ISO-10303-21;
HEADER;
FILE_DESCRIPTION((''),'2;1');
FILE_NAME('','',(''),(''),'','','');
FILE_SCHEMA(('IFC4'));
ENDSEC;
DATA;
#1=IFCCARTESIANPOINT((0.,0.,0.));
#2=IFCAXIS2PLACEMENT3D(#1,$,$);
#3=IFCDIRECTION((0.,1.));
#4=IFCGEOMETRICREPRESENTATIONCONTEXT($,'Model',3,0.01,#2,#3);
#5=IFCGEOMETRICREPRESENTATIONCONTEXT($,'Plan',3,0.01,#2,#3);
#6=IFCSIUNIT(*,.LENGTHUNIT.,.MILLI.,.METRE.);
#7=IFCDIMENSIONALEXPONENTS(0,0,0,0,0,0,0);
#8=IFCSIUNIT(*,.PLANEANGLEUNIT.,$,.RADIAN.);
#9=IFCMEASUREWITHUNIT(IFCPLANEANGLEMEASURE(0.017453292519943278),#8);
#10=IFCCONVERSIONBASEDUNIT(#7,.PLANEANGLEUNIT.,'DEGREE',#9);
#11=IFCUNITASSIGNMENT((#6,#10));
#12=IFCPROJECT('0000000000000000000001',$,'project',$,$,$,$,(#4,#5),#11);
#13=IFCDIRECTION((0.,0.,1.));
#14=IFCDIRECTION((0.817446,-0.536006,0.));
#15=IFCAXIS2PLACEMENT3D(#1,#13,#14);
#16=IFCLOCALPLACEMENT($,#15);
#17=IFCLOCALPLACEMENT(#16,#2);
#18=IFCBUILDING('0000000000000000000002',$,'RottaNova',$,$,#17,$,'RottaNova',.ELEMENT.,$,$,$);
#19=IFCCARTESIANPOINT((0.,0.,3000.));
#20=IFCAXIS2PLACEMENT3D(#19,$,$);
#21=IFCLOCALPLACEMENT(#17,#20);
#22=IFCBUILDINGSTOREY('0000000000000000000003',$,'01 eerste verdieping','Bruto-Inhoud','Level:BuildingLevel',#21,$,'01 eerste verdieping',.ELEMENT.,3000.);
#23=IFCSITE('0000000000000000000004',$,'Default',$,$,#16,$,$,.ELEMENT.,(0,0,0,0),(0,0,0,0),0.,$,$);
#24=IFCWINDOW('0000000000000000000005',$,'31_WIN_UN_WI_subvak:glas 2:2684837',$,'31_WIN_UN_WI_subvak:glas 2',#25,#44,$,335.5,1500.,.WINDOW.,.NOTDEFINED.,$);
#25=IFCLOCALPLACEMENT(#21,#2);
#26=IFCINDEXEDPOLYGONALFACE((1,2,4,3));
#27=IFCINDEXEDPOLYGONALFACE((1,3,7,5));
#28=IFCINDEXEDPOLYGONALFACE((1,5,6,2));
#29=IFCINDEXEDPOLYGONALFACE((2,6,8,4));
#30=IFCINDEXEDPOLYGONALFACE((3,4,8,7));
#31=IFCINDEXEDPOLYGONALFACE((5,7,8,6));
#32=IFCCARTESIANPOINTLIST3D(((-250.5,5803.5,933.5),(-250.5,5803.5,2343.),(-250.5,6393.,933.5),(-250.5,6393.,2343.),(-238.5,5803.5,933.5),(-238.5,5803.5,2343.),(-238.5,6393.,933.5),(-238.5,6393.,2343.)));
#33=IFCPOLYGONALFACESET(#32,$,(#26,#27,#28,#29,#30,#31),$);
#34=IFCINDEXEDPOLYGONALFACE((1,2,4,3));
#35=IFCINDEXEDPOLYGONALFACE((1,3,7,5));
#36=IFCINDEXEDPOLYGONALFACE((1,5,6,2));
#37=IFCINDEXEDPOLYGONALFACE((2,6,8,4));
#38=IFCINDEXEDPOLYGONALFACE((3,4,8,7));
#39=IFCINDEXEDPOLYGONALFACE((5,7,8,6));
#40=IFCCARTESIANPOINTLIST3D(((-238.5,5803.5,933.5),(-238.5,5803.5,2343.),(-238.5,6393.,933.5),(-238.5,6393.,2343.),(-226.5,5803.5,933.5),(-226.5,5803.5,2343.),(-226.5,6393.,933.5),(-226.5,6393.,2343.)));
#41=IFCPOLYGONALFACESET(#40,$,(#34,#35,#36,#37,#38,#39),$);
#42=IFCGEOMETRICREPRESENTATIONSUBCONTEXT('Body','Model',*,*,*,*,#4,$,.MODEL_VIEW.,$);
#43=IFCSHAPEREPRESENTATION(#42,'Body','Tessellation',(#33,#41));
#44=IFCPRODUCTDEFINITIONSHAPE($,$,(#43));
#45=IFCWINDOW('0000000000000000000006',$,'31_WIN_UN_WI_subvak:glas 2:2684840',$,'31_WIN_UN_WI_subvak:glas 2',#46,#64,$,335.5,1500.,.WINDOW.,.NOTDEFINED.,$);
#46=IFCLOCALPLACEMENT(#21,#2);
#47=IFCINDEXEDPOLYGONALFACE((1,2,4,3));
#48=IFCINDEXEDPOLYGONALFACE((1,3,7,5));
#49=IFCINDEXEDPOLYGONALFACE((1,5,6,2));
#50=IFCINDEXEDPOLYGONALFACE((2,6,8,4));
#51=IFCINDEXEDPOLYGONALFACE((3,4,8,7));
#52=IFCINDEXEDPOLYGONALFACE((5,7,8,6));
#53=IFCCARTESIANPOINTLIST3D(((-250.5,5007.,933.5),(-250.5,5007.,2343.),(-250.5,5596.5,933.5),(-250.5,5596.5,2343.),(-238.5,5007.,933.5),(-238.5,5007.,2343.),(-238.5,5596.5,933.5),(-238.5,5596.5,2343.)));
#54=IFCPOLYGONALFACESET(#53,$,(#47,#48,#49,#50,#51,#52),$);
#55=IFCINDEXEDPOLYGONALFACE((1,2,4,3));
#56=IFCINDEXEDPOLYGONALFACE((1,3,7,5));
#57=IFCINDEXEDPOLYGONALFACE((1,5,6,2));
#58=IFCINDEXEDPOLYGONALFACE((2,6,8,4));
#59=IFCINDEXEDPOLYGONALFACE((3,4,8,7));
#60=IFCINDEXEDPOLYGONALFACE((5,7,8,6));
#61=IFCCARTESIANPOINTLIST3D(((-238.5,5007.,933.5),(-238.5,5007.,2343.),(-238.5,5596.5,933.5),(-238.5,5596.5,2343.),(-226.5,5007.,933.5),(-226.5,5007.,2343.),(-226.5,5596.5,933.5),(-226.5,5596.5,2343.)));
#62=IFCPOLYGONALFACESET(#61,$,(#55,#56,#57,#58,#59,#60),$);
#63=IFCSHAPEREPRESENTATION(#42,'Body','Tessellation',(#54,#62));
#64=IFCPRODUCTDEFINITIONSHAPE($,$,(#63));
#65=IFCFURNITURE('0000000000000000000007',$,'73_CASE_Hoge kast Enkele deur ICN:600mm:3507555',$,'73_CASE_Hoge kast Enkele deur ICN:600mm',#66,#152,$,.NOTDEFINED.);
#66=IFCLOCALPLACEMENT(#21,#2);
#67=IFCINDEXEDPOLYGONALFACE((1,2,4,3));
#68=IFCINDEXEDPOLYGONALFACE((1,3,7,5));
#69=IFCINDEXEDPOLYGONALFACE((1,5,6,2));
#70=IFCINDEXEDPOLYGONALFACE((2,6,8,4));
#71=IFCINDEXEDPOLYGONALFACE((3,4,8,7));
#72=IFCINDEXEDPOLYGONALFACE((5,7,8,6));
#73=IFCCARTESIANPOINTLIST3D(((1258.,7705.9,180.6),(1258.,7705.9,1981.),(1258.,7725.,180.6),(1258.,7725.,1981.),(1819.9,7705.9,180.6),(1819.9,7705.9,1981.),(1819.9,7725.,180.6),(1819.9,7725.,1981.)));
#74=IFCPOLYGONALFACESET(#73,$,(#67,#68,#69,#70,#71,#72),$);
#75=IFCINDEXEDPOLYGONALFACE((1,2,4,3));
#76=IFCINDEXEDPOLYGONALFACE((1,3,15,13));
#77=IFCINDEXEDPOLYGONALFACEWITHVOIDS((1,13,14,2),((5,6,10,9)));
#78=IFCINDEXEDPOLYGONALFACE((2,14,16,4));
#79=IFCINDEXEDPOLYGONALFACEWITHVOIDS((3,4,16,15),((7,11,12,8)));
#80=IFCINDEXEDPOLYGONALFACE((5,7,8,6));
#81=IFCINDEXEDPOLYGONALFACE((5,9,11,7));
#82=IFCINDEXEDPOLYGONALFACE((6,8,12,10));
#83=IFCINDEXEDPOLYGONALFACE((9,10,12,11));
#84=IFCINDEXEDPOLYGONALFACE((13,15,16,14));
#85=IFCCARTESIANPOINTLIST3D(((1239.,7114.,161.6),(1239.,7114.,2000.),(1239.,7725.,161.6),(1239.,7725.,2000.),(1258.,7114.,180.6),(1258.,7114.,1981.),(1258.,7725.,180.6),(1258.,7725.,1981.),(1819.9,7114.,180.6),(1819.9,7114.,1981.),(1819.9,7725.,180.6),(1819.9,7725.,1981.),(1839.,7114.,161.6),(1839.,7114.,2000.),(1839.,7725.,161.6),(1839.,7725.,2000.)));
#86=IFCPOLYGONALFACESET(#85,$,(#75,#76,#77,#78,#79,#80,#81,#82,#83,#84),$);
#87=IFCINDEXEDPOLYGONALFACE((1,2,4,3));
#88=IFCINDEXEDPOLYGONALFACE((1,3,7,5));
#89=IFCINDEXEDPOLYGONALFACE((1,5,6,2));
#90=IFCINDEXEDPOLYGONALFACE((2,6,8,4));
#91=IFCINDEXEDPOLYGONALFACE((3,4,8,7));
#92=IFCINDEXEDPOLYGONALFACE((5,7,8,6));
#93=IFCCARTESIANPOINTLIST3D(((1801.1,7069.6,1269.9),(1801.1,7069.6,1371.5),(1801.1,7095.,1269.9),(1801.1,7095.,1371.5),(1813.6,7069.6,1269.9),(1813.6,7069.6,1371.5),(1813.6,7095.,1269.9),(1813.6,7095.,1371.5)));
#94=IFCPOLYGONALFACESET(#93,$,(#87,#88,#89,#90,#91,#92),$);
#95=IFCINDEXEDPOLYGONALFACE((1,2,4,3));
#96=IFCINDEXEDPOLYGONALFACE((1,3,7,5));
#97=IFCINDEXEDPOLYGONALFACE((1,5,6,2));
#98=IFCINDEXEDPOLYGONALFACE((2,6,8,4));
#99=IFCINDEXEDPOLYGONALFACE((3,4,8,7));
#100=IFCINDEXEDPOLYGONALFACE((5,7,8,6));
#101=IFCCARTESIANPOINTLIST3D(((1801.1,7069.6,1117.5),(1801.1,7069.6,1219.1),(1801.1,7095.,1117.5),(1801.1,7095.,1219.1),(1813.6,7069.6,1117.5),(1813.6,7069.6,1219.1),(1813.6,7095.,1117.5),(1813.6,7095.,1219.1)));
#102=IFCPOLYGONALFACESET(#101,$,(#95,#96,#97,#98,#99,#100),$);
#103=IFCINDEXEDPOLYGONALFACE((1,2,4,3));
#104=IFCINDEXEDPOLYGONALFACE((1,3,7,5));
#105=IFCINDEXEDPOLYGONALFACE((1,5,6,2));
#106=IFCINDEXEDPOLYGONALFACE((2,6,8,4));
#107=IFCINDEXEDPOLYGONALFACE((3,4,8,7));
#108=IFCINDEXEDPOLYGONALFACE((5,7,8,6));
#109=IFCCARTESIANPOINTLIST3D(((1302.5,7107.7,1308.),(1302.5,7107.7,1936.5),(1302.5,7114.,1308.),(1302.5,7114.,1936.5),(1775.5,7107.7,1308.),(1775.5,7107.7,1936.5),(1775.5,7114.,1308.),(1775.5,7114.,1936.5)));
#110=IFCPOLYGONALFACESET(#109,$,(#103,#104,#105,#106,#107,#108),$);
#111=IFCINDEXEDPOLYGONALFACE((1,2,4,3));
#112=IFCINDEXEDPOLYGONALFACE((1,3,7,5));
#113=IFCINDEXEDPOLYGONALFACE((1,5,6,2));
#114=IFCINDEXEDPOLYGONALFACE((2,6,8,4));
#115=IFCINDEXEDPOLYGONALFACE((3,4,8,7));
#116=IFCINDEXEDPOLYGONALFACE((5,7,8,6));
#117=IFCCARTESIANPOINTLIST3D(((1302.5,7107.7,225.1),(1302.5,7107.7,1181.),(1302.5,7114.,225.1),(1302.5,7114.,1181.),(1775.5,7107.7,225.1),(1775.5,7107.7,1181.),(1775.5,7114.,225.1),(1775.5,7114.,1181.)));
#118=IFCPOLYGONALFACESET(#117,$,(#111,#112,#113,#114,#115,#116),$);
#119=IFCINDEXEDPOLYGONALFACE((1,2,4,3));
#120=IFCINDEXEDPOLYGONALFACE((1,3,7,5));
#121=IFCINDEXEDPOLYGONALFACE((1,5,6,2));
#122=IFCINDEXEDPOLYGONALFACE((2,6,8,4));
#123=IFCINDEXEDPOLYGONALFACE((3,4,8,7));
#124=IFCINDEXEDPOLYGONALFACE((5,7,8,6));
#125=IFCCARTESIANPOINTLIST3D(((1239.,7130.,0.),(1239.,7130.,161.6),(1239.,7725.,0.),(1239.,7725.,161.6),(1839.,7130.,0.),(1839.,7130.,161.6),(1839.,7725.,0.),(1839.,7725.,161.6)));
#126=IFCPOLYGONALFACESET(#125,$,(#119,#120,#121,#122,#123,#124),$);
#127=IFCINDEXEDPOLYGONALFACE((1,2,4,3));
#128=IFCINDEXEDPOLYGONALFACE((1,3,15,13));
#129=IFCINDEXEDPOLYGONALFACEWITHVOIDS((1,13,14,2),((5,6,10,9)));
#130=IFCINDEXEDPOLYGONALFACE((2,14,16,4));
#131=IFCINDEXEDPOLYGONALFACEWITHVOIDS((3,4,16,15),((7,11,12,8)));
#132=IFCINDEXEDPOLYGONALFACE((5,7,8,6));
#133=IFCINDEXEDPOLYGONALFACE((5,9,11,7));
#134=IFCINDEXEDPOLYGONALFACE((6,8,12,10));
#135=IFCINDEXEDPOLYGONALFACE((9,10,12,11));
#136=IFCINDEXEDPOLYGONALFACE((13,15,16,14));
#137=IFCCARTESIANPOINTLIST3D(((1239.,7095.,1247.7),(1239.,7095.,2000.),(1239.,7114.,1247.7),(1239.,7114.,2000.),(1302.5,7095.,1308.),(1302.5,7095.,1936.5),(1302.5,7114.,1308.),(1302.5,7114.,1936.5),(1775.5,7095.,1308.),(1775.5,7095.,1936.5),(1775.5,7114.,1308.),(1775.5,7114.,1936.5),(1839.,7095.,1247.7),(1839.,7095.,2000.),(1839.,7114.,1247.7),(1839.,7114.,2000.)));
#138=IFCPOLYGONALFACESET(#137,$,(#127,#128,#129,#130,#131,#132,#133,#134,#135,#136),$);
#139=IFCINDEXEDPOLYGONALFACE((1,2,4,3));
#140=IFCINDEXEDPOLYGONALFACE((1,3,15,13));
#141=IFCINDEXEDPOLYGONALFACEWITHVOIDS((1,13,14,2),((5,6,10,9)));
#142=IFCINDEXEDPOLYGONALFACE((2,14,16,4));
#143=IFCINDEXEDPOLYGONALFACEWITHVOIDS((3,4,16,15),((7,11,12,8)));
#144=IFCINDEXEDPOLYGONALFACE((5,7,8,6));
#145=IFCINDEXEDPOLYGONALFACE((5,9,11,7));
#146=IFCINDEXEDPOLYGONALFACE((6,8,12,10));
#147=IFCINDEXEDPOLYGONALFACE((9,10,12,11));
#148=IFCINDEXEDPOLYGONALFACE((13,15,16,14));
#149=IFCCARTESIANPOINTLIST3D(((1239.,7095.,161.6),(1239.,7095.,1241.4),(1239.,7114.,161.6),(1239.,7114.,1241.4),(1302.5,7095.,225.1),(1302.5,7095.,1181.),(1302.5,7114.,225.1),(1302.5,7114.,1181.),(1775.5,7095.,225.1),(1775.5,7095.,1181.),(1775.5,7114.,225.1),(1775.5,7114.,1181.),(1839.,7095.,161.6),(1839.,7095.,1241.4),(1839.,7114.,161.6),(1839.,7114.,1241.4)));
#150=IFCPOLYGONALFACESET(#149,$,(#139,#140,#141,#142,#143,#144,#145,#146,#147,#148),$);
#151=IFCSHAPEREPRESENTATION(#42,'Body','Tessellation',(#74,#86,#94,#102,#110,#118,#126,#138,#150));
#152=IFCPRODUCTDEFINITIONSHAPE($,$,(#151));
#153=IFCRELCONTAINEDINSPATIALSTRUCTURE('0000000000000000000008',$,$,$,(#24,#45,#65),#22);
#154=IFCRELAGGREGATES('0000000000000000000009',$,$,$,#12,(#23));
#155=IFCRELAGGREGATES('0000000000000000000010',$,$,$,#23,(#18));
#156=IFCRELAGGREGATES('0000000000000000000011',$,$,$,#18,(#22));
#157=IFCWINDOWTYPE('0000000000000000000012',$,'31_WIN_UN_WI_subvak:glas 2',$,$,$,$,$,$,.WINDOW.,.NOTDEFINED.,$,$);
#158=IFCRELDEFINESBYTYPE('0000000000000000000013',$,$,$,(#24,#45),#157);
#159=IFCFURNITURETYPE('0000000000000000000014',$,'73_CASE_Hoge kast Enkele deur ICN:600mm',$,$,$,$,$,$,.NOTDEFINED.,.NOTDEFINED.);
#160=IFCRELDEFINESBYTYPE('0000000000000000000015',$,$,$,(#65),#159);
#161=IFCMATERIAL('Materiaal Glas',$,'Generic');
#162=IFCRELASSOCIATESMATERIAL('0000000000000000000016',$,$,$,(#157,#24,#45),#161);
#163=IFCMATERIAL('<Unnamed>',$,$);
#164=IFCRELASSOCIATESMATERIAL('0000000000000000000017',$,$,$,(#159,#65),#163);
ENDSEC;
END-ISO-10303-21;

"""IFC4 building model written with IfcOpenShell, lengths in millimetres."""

from ifc_helpers import new_model, entity, si_unit, converted_unit, direction, frame, origin, place, context, subcontext, project, spatial, indexed_curve, outline, extrude, source, transform, mapped, material, type_object, type_shapes, element, save


model = new_model("IFC4")

# Units and contexts
model_context = context("Model", 3, precision=0.01, world=origin(), true_north=direction((0.0, 1.0)))
plan_context = context("Plan", 3, precision=0.01, world=origin(), true_north=direction((0.0, 1.0)))
body_context = subcontext(model_context, "Body", "Model", "MODEL_VIEW")
ifc_project = project(units=[si_unit("LENGTHUNIT", "METRE", prefix="MILLI"), converted_unit("PLANEANGLEUNIT", "DEGREE", entity("IfcPlaneAngleMeasure", 0.017453292519943278), si_unit("PLANEANGLEUNIT", "RADIAN"), dimensions=[0, 0, 0, 0, 0, 0, 0])], contexts=[model_context, plan_context])

# Site, building, storey
site_placement = place(None, frame((0.0, 0.0, 0.0), z_axis=(0.0, 0.0, 1.0), x_axis=(0.817446, -0.536006, 0.0)))
site = spatial("IfcSite", under=ifc_project, at=site_placement, Name="Default", CompositionType="ELEMENT", RefLatitude=(0, 0, 0, 0), RefLongitude=(0, 0, 0, 0), RefElevation=0.0)
building_placement = place(site_placement, origin())
building = spatial("IfcBuilding", under=site, at=building_placement, Name="RottaNova", LongName="RottaNova", CompositionType="ELEMENT")
storey_placement = place(building_placement, frame((0.0, 0.0, 3000.0)))
storey = spatial("IfcBuildingStorey", under=building, at=storey_placement, Name="01 eerste verdieping", Description="Bruto-Inhoud", ObjectType="Level:BuildingLevel", LongName="01 eerste verdieping", CompositionType="ELEMENT", Elevation=3000.0)

# Shared definitions
ifc_material_1 = material(Name="Materiaal Glas", Category="Generic")

# Windows
window_type = type_object("IfcWindowType", Name="31_WIN_UN_WI_subvak:glas 2", PartitioningType="NOTDEFINED", PredefinedType="WINDOW", material=ifc_material_1)
shared_shape_1 = source(origin(), body_context, "Body", "SweptSolid", [
    extrude(outline(indexed_curve([(-294.7, -6.0), (294.7, -6.0), (294.7, 6.0), (-294.7, 6.0), (-294.7, -6.0)], self_intersect=False)), frame((0.0, -6.0, 0.0)), (0.0, 0.0, 1.0), 1409.5),
    extrude(outline(indexed_curve([(-294.8, -6.0), (294.8, -6.0), (294.8, 6.0), (-294.8, 6.0), (-294.8, -6.0)], self_intersect=False)), frame((0.0, 6.0, 0.0)), (0.0, 0.0, 1.0), 1409.5),
])
type_shapes(window_type, [shared_shape_1])
for number, where, z_axis, x_axis, name in (
    (1, (-238.5, 6098.2, 933.5), (0.0, 0.0, 1.0), (0.0, -1.0, 0.0), "31_WIN_UN_WI_subvak:glas 2:2684837"),
    (2, (-238.5, 5301.7, 933.5), (0.0, 0.0, 1.0), (0.0, -1.0, 0.0), "31_WIN_UN_WI_subvak:glas 2:2684840"),
):
    element("IfcWindow", number, at=place(storey_placement, frame(where, z_axis=z_axis, x_axis=x_axis)), inside=storey, type_object=window_type, material=ifc_material_1, Name=name, ObjectType="31_WIN_UN_WI_subvak:glas 2", OverallHeight=335.5, OverallWidth=1500.0, PartitioningType="NOTDEFINED", PredefinedType="WINDOW", context=body_context, shape_type="MappedRepresentation", body=[
        mapped(shared_shape_1, transform((0.0, 0.0, 0.0), scale=1.0)),
    ])

# Furniture
ifc_material_2 = material(Name="<Unnamed>")
furniture_type = type_object("IfcFurnitureType", Name="73_CASE_Hoge kast Enkele deur ICN:600mm", AssemblyPlace="NOTDEFINED", PredefinedType="NOTDEFINED", material=ifc_material_2)
shared_shape_2 = source(origin(), body_context, "Body", "SweptSolid", [
    extrude(outline(indexed_curve([(-9.5, -280.9), (9.5, -280.9), (9.5, 280.9), (-9.5, 280.9), (-9.5, -280.9)], self_intersect=False)), frame((18.7, -9.5, 180.6), z_axis=(0.0, 0.0, 1.0), x_axis=(0.0, 1.0, 0.0)), (0.0, 0.0, 1.0), 1800.3),
    extrude(outline(indexed_curve([(-300.0, -919.2), (300.0, -919.2), (300.0, 919.2), (-300.0, 919.2), (-300.0, -919.2)], self_intersect=False), holes=[indexed_curve([(-280.9, 900.2), (281.0, 900.2), (281.0, -900.2), (-280.9, -900.2), (-280.9, 900.2)], self_intersect=False)]), frame((18.7, -610.9, 1080.8), z_axis=(0.0, 1.0, 0.0), x_axis=(-1.0, 0.0, 0.0)), (0.0, 0.0, 1.0), 610.9),
    extrude(outline(indexed_curve([(-12.7, -6.3), (12.7, -6.3), (12.7, 6.3), (-12.7, 6.3), (-12.7, -6.3)], self_intersect=False)), frame((287.1, -642.7, 1269.9), z_axis=(0.0, 0.0, 1.0), x_axis=(0.0, 1.0, 0.0)), (0.0, 0.0, 1.0), 101.6),
    extrude(outline(indexed_curve([(-12.7, -6.3), (12.7, -6.3), (12.7, 6.3), (-12.7, 6.3), (-12.7, -6.3)], self_intersect=False)), frame((287.1, -642.7, 1117.5), z_axis=(0.0, 0.0, 1.0), x_axis=(0.0, 1.0, 0.0)), (0.0, 0.0, 1.0), 101.6),
    extrude(outline(indexed_curve([(-3.2, -236.5), (3.2, -236.5), (3.2, 236.5), (-3.2, 236.5), (-3.2, -236.5)], self_intersect=False)), frame((18.7, -614.1, 1308.0), z_axis=(0.0, 0.0, 1.0), x_axis=(0.0, 1.0, 0.0)), (0.0, 0.0, 1.0), 628.5),
    extrude(outline(indexed_curve([(-3.2, -236.5), (3.2, -236.5), (3.2, 236.5), (-3.2, 236.5), (-3.2, -236.5)], self_intersect=False)), frame((18.7, -614.1, 225.1), z_axis=(0.0, 0.0, 1.0), x_axis=(0.0, 1.0, 0.0)), (0.0, 0.0, 1.0), 956.0),
    extrude(outline(indexed_curve([(-300.0, -297.5), (300.0, -297.5), (300.0, 297.5), (-300.0, 297.5), (-300.0, -297.5)], self_intersect=False)), frame((18.7, -297.5, 0.0), z_axis=(0.0, 0.0, 1.0), x_axis=(-1.0, 0.0, 0.0)), (0.0, 0.0, 1.0), 161.6),
    extrude(outline(indexed_curve([(-376.1, -300.0), (376.1, -300.0), (376.1, 300.0), (-376.1, 300.0), (-376.1, -300.0)], self_intersect=False), holes=[indexed_curve([(-312.6, -236.5), (-312.6, 236.5), (315.8, 236.5), (315.8, -236.5), (-312.6, -236.5)], self_intersect=False)]), frame((18.7, -630.0, 1623.9), z_axis=(0.0, 1.0, 0.0), x_axis=(0.0, 0.0, -1.0)), (0.0, 0.0, 1.0), 19.1),
    extrude(outline(indexed_curve([(-300.0, -539.9), (300.0, -539.9), (300.0, 539.9), (-300.0, 539.9), (-300.0, -539.9)], self_intersect=False), holes=[indexed_curve([(-236.5, 479.6), (236.5, 479.6), (236.5, -476.4), (-236.5, -476.4), (-236.5, 479.6)], self_intersect=False)]), frame((18.7, -630.0, 701.5), z_axis=(0.0, 1.0, 0.0), x_axis=(-1.0, 0.0, 0.0)), (0.0, 0.0, 1.0), 19.1),
])
type_shapes(furniture_type, [shared_shape_2])
for number, where, name in (
    (3, (1520.3, 7725.0, 0.0), "73_CASE_Hoge kast Enkele deur ICN:600mm:3507555"),
):
    element("IfcFurniture", number, at=place(storey_placement, frame(where)), inside=storey, type_object=furniture_type, material=ifc_material_2, Name=name, ObjectType="73_CASE_Hoge kast Enkele deur ICN:600mm", PredefinedType="NOTDEFINED", context=body_context, shape_type="MappedRepresentation", body=[
        mapped(shared_shape_2, transform((0.0, 0.0, 0.0), scale=1.0)),
    ])

save(model, "model.ifc")
